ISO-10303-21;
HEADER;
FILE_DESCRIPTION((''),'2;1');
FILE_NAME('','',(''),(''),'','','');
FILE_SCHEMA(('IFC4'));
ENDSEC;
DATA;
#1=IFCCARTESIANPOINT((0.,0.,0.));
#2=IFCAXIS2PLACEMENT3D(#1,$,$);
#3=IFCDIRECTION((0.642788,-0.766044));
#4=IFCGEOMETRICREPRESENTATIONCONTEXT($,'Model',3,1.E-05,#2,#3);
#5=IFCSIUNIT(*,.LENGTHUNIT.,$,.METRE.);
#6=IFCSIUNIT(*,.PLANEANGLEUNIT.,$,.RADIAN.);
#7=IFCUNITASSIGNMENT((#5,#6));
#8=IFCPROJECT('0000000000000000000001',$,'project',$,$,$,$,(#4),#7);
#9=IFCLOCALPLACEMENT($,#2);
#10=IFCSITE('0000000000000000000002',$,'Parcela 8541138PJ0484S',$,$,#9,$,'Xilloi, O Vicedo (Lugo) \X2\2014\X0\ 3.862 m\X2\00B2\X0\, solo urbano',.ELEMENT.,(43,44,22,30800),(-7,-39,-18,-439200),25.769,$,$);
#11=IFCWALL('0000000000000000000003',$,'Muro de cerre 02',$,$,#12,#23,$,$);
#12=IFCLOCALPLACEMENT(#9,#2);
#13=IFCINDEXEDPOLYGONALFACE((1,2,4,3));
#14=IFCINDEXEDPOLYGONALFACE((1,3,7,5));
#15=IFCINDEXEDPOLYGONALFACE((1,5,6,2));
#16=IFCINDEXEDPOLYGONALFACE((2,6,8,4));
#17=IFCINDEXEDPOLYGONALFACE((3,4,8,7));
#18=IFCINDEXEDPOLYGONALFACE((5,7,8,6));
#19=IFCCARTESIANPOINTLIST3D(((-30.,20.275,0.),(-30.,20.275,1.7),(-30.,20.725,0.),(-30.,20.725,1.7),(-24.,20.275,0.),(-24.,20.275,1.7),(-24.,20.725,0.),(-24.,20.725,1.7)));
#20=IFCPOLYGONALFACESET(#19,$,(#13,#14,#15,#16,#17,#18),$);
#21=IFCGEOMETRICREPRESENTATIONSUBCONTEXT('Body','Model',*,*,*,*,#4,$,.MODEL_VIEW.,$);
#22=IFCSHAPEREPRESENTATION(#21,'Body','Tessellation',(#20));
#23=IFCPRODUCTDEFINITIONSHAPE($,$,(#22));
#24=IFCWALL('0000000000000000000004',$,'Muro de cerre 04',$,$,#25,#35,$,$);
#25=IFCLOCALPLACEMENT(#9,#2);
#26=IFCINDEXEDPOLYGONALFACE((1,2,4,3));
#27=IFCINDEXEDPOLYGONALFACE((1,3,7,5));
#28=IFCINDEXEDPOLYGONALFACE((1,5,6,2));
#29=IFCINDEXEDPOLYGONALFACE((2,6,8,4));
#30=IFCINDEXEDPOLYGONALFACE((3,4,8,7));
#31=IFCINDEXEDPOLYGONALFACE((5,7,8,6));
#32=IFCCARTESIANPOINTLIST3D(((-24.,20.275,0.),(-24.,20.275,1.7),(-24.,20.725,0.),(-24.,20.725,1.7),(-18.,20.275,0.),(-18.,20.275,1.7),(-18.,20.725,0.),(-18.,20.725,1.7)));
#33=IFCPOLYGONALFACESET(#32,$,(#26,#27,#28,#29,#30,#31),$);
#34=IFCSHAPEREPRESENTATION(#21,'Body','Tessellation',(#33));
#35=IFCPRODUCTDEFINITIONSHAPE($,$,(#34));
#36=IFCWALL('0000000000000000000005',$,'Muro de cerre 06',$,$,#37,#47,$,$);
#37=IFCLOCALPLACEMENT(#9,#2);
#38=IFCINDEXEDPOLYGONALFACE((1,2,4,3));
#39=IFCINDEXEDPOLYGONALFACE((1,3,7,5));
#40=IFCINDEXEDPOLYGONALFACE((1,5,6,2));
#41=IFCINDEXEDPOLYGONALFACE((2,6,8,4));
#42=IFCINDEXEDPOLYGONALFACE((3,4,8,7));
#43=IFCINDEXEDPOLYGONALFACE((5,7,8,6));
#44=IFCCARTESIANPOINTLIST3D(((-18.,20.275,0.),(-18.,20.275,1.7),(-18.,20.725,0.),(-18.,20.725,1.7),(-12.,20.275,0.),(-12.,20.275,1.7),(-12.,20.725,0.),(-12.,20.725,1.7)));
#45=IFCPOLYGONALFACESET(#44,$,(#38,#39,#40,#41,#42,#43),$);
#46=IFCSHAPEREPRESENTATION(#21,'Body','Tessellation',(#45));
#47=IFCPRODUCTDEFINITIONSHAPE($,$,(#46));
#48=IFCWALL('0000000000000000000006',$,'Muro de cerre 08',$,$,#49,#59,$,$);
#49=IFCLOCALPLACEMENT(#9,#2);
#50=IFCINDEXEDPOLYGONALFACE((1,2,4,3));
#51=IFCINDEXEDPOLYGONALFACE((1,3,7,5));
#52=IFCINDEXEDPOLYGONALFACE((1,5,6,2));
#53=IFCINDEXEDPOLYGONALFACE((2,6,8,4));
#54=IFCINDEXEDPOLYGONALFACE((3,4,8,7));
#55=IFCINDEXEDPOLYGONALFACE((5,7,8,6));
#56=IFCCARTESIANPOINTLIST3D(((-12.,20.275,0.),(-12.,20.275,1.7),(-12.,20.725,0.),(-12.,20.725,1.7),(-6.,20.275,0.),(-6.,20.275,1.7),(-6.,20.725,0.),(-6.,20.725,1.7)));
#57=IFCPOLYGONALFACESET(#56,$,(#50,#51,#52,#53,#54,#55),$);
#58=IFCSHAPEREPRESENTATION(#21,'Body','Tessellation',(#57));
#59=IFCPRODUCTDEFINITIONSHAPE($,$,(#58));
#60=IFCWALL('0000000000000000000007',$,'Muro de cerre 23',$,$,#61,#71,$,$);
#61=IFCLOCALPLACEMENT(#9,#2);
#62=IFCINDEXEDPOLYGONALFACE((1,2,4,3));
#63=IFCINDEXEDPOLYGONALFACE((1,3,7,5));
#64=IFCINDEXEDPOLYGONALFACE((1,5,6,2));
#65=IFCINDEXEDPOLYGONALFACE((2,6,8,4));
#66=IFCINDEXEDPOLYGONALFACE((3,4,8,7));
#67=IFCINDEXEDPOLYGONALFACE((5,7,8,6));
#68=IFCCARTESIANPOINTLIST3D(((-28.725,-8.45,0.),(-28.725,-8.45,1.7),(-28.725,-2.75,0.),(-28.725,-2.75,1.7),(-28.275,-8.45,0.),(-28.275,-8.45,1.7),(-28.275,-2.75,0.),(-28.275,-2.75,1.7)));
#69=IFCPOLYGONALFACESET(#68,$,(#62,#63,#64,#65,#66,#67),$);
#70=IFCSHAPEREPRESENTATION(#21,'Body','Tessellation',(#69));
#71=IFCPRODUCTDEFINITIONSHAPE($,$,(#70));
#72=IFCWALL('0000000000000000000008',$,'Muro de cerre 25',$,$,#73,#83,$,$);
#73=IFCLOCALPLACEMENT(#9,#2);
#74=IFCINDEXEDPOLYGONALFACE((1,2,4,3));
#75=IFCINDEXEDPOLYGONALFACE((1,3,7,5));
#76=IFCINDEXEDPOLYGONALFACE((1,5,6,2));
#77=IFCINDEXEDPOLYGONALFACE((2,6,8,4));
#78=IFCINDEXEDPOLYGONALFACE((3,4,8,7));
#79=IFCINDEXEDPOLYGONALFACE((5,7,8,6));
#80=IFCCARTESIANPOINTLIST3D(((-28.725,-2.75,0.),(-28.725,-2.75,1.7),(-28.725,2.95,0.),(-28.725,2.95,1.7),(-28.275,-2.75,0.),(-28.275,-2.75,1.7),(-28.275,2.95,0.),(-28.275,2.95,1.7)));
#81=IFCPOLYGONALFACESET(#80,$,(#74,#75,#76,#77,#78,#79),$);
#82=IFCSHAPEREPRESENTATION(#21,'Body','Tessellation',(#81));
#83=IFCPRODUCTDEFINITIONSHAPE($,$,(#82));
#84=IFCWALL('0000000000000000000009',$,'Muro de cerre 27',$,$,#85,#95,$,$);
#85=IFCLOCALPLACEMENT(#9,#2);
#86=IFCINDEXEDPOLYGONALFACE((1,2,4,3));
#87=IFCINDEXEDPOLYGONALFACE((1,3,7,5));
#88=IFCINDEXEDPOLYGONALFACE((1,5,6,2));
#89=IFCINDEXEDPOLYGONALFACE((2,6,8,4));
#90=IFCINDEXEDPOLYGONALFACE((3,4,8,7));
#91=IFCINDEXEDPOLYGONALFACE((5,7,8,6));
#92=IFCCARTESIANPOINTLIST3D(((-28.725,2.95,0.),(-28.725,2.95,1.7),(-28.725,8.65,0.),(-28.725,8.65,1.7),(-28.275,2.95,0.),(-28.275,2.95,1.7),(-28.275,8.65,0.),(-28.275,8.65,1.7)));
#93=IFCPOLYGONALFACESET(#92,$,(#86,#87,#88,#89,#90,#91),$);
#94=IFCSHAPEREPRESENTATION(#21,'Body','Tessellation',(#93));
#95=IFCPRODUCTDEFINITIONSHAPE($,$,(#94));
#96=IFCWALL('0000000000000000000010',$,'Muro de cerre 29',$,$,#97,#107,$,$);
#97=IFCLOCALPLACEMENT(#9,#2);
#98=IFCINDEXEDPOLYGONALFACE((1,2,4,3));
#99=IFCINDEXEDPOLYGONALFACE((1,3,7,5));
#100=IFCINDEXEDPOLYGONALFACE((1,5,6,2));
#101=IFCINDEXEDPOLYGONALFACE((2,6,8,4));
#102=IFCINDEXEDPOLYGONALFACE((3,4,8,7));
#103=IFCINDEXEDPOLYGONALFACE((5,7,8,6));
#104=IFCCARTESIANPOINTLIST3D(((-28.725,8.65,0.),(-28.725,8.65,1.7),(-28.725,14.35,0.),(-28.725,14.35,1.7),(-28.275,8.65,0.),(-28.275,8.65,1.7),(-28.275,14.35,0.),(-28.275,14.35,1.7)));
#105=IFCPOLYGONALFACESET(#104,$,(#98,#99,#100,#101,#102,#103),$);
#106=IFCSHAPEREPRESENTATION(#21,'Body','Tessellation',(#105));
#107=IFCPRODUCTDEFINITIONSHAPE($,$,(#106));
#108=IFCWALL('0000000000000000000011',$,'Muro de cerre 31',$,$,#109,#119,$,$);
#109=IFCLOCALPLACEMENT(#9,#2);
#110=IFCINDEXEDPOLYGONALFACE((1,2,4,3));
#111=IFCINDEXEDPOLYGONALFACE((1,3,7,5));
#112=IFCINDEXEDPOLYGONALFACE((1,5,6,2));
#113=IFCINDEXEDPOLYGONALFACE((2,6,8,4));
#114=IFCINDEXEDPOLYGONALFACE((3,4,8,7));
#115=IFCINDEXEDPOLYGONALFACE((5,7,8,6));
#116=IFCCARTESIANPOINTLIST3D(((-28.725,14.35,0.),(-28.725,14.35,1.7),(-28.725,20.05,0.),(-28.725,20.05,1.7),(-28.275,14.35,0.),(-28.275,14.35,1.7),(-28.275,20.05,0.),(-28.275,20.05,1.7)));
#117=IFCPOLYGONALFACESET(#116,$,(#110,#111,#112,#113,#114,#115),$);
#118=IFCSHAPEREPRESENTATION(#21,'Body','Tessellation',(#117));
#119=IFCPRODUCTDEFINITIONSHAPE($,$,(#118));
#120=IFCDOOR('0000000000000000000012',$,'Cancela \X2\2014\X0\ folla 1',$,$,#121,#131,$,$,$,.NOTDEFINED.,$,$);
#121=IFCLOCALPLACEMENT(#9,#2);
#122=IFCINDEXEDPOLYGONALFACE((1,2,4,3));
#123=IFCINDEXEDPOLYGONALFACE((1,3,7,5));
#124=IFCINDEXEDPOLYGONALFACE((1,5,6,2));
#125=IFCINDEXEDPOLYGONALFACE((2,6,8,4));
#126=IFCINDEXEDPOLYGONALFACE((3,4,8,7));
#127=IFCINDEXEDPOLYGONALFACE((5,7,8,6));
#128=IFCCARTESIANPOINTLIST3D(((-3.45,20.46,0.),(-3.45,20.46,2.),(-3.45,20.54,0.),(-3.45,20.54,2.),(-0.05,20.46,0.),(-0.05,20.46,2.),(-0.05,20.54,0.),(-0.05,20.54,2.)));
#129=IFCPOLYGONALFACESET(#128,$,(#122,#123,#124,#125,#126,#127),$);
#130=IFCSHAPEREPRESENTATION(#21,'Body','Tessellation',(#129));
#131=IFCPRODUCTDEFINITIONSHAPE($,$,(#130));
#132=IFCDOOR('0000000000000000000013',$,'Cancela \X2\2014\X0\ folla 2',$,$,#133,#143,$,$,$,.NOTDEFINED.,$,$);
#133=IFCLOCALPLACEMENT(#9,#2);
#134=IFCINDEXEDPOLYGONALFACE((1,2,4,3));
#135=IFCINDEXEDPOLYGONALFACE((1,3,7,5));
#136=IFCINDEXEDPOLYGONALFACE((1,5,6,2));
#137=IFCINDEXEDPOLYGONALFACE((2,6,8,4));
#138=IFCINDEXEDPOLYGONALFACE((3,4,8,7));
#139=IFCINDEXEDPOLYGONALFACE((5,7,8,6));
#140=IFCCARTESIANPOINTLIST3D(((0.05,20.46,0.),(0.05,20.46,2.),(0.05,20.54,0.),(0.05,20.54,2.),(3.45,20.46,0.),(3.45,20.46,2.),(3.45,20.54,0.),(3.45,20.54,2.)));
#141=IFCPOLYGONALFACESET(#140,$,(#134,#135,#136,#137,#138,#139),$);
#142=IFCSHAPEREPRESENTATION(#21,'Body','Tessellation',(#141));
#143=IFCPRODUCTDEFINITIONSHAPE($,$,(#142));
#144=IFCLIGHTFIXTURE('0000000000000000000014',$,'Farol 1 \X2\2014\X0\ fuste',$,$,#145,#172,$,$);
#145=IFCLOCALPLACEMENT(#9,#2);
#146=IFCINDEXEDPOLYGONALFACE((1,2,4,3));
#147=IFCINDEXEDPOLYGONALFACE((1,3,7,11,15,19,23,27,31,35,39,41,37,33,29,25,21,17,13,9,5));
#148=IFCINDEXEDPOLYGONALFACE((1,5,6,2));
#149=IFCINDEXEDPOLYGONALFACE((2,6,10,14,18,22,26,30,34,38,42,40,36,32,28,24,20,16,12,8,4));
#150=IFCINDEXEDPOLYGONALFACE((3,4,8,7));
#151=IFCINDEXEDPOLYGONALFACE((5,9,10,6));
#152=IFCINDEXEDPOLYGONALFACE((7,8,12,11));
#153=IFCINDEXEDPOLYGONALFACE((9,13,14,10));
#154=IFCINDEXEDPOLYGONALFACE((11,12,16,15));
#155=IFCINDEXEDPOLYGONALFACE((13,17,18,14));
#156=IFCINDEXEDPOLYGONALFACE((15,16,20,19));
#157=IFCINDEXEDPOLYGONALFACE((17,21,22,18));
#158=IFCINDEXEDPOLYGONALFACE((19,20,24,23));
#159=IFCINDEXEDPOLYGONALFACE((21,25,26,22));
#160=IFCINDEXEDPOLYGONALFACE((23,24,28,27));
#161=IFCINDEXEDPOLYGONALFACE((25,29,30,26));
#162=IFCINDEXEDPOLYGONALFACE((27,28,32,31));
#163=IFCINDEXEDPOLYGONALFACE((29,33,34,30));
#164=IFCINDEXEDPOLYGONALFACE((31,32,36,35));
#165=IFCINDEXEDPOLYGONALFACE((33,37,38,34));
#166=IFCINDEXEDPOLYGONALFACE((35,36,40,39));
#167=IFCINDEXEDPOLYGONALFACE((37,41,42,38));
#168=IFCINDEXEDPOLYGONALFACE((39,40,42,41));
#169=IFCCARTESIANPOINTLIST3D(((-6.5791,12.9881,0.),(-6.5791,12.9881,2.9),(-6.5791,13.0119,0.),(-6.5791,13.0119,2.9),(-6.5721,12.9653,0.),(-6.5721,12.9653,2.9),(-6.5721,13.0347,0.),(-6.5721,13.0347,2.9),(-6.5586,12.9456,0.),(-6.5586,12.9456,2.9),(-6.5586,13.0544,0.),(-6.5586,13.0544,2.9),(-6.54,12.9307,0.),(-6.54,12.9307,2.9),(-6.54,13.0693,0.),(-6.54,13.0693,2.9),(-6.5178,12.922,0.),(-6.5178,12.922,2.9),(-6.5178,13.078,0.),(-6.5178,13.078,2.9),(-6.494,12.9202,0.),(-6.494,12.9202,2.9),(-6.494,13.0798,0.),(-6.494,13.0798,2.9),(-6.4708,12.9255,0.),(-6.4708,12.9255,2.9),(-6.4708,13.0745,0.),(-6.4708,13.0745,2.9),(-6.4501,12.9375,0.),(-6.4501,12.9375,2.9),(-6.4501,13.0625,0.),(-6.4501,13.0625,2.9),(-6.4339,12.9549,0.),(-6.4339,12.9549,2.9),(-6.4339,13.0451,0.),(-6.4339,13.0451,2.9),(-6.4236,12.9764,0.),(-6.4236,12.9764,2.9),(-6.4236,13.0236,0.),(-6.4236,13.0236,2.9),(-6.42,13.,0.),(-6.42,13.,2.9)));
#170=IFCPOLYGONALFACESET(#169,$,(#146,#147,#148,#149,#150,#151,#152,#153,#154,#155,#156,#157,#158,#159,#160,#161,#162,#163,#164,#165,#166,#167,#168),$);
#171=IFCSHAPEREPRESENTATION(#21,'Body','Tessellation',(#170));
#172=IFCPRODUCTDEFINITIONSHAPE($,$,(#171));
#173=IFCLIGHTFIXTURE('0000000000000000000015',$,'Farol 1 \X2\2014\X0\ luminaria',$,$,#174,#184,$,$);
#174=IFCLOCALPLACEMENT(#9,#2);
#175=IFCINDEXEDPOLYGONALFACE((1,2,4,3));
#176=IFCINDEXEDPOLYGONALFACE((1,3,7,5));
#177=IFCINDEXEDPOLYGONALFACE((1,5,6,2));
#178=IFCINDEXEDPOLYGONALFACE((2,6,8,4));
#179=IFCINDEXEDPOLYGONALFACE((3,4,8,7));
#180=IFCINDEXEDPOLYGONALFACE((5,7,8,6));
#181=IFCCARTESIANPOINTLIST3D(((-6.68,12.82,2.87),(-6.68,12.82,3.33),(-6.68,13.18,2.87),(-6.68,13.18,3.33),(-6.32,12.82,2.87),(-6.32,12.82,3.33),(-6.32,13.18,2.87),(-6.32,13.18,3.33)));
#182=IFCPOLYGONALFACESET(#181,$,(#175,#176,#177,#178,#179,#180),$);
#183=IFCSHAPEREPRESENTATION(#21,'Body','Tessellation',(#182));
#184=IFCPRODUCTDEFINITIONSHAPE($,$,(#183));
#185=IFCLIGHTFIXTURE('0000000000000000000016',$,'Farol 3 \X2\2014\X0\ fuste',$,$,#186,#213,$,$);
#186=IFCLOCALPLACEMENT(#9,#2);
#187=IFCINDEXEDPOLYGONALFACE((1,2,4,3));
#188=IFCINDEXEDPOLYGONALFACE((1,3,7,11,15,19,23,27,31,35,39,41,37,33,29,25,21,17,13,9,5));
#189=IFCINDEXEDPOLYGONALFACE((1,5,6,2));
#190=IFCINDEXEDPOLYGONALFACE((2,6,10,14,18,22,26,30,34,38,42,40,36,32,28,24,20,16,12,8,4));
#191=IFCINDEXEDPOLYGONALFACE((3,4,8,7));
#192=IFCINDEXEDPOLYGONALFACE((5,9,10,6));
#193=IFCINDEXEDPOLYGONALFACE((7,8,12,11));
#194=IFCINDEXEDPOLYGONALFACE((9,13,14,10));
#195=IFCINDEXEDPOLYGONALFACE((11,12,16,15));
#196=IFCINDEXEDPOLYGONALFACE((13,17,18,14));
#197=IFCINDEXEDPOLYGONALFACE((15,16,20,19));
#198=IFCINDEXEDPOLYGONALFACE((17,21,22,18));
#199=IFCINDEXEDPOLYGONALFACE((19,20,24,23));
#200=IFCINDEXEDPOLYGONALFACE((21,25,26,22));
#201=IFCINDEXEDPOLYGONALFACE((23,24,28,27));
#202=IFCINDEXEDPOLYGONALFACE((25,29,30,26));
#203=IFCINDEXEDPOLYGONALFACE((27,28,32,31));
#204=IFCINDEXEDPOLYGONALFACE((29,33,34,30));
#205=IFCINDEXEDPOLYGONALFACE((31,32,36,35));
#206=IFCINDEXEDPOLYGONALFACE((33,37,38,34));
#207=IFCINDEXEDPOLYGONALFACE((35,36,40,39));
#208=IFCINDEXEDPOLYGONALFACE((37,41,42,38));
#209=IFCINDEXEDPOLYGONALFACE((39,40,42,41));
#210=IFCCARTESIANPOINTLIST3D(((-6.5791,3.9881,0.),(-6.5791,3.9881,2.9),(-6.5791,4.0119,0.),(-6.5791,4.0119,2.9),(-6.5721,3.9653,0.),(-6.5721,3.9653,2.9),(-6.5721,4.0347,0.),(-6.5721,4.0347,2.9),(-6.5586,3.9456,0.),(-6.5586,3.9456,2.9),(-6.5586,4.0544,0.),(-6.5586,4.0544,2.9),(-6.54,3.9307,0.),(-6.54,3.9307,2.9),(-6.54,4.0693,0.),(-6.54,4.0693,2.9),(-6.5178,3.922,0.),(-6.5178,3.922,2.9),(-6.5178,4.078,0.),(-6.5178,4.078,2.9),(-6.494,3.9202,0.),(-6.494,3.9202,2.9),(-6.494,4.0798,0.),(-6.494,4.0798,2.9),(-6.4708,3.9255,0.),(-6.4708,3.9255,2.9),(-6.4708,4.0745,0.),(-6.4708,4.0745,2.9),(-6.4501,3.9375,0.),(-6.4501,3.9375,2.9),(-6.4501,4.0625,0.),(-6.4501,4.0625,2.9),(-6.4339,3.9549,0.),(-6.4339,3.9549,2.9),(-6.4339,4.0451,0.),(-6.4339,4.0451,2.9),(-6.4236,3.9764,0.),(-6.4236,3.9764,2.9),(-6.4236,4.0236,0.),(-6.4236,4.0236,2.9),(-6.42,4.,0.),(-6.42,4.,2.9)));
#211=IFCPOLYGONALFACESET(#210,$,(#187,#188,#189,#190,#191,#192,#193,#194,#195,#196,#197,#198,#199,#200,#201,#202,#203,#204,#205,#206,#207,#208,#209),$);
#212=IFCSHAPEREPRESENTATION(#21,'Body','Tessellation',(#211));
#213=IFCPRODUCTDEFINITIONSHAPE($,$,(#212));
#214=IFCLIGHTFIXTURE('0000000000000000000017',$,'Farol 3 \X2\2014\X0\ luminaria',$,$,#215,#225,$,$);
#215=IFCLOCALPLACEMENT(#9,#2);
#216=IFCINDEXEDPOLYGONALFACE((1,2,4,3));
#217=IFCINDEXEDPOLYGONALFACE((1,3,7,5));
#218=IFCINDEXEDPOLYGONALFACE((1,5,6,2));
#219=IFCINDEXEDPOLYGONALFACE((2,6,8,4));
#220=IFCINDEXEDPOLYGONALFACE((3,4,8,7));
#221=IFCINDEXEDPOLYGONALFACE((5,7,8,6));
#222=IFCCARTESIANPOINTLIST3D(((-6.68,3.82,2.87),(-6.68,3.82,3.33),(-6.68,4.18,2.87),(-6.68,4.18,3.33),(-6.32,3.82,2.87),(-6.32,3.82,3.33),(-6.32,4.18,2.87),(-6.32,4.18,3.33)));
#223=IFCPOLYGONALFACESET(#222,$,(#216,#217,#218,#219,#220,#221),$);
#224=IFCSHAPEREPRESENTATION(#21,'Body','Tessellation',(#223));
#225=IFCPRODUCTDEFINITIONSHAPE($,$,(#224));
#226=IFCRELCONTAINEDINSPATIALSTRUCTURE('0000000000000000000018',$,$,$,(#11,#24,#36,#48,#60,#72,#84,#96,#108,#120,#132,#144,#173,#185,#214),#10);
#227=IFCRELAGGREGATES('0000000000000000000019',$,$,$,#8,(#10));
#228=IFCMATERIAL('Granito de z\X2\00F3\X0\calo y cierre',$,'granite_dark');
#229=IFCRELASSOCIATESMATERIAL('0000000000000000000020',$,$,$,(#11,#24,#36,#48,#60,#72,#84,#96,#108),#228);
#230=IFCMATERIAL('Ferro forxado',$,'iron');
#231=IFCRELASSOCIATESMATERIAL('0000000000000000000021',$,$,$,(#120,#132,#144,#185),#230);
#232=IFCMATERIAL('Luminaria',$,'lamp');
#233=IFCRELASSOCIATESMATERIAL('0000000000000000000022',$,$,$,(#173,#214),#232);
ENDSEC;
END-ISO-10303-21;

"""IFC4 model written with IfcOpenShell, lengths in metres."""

from ifc_helpers import new_model, si_unit, direction, frame, origin, origin_2d, place, context, subcontext, project, spatial, rectangle, circle, extrude, material, element, save


model = new_model("IFC4")

# Units and contexts
model_context = context("Model", 3, precision=1e-05, world=origin(), true_north=direction((0.642788, -0.766044)))
body_context = subcontext(model_context, "Body", "Model", "MODEL_VIEW")
ifc_project = project(units=[si_unit("LENGTHUNIT", "METRE"), si_unit("PLANEANGLEUNIT", "RADIAN")], contexts=[model_context])

# Site
site_placement = place(None, origin())
site = spatial("IfcSite", under=ifc_project, at=site_placement, Name="Parcela 8541138PJ0484S", LongName="Xilloi, O Vicedo (Lugo) — 3.862 m², solo urbano", CompositionType="ELEMENT", RefLatitude=(43, 44, 22, 30800), RefLongitude=(-7, -39, -18, -439200), RefElevation=25.769)

# Walls
ifc_material_1 = material(Name="Granito de zócalo y cierre", Category="granite_dark")
for number, where, name in (
    (1, (-27.0, 20.5, 0.85), "Muro de cerre 02"),
    (2, (-21.0, 20.5, 0.85), "Muro de cerre 04"),
    (3, (-15.0, 20.5, 0.85), "Muro de cerre 06"),
    (4, (-9.0, 20.5, 0.85), "Muro de cerre 08"),
):
    element("IfcWall", number, at=place(site_placement, frame(where)), inside=site, material=ifc_material_1, Name=name, context=body_context, shape_type="SweptSolid", body=[
        extrude(rectangle(XDim=6.0, YDim=0.45, at=origin_2d()), frame((0.0, 0.0, -0.85)), (0.0, 0.0, 1.0), 1.7),
    ])
for number, where, name in (
    (5, (-28.5, -5.6, 0.85), "Muro de cerre 23"),
    (6, (-28.5, 0.1, 0.85), "Muro de cerre 25"),
    (7, (-28.5, 5.8, 0.85), "Muro de cerre 27"),
    (8, (-28.5, 11.5, 0.85), "Muro de cerre 29"),
    (9, (-28.5, 17.2, 0.85), "Muro de cerre 31"),
):
    element("IfcWall", number, at=place(site_placement, frame(where)), inside=site, material=ifc_material_1, Name=name, context=body_context, shape_type="SweptSolid", body=[
        extrude(rectangle(XDim=0.45, YDim=5.7, at=origin_2d()), frame((0.0, 0.0, -0.85)), (0.0, 0.0, 1.0), 1.7),
    ])

# Doors
ifc_material_2 = material(Name="Ferro forxado", Category="iron")
for number, where, name in (
    (10, (-1.75, 20.5, 1.0), "Cancela — folla 1"),
    (11, (1.75, 20.5, 1.0), "Cancela — folla 2"),
):
    element("IfcDoor", number, at=place(site_placement, frame(where)), inside=site, material=ifc_material_2, Name=name, PredefinedType="NOTDEFINED", context=body_context, shape_type="SweptSolid", body=[
        extrude(rectangle(XDim=3.4, YDim=0.08, at=origin_2d()), frame((0.0, 0.0, -1.0)), (0.0, 0.0, 1.0), 2.0),
    ])

# Light fixtures
light_fixture_1_placement = place(site_placement, frame((-6.5, 13.0, 1.45)))
element("IfcLightFixture", 12, at=light_fixture_1_placement, inside=site, material=ifc_material_2, Name="Farol 1 — fuste", context=body_context, shape_type="SweptSolid", body=[
    extrude(circle(Radius=0.08, at=origin_2d()), frame((0.0, 0.0, -1.45)), (0.0, 0.0, 1.0), 2.9),
])
ifc_material_3 = material(Name="Luminaria", Category="lamp")
light_fixture_2_placement = place(site_placement, frame((-6.5, 13.0, 3.1)))
element("IfcLightFixture", 13, at=light_fixture_2_placement, inside=site, material=ifc_material_3, Name="Farol 1 — luminaria", context=body_context, shape_type="SweptSolid", body=[
    extrude(rectangle(XDim=0.36, YDim=0.36, at=origin_2d()), frame((0.0, 0.0, -0.23)), (0.0, 0.0, 1.0), 0.46),
])
light_fixture_3_placement = place(site_placement, frame((-6.5, 4.0, 1.45)))
element("IfcLightFixture", 14, at=light_fixture_3_placement, inside=site, material=ifc_material_2, Name="Farol 3 — fuste", context=body_context, shape_type="SweptSolid", body=[
    extrude(circle(Radius=0.08, at=origin_2d()), frame((0.0, 0.0, -1.45)), (0.0, 0.0, 1.0), 2.9),
])
light_fixture_4_placement = place(site_placement, frame((-6.5, 4.0, 3.1)))
element("IfcLightFixture", 15, at=light_fixture_4_placement, inside=site, material=ifc_material_3, Name="Farol 3 — luminaria", context=body_context, shape_type="SweptSolid", body=[
    extrude(rectangle(XDim=0.36, YDim=0.36, at=origin_2d()), frame((0.0, 0.0, -0.23)), (0.0, 0.0, 1.0), 0.46),
])

save(model, "model.ifc")
